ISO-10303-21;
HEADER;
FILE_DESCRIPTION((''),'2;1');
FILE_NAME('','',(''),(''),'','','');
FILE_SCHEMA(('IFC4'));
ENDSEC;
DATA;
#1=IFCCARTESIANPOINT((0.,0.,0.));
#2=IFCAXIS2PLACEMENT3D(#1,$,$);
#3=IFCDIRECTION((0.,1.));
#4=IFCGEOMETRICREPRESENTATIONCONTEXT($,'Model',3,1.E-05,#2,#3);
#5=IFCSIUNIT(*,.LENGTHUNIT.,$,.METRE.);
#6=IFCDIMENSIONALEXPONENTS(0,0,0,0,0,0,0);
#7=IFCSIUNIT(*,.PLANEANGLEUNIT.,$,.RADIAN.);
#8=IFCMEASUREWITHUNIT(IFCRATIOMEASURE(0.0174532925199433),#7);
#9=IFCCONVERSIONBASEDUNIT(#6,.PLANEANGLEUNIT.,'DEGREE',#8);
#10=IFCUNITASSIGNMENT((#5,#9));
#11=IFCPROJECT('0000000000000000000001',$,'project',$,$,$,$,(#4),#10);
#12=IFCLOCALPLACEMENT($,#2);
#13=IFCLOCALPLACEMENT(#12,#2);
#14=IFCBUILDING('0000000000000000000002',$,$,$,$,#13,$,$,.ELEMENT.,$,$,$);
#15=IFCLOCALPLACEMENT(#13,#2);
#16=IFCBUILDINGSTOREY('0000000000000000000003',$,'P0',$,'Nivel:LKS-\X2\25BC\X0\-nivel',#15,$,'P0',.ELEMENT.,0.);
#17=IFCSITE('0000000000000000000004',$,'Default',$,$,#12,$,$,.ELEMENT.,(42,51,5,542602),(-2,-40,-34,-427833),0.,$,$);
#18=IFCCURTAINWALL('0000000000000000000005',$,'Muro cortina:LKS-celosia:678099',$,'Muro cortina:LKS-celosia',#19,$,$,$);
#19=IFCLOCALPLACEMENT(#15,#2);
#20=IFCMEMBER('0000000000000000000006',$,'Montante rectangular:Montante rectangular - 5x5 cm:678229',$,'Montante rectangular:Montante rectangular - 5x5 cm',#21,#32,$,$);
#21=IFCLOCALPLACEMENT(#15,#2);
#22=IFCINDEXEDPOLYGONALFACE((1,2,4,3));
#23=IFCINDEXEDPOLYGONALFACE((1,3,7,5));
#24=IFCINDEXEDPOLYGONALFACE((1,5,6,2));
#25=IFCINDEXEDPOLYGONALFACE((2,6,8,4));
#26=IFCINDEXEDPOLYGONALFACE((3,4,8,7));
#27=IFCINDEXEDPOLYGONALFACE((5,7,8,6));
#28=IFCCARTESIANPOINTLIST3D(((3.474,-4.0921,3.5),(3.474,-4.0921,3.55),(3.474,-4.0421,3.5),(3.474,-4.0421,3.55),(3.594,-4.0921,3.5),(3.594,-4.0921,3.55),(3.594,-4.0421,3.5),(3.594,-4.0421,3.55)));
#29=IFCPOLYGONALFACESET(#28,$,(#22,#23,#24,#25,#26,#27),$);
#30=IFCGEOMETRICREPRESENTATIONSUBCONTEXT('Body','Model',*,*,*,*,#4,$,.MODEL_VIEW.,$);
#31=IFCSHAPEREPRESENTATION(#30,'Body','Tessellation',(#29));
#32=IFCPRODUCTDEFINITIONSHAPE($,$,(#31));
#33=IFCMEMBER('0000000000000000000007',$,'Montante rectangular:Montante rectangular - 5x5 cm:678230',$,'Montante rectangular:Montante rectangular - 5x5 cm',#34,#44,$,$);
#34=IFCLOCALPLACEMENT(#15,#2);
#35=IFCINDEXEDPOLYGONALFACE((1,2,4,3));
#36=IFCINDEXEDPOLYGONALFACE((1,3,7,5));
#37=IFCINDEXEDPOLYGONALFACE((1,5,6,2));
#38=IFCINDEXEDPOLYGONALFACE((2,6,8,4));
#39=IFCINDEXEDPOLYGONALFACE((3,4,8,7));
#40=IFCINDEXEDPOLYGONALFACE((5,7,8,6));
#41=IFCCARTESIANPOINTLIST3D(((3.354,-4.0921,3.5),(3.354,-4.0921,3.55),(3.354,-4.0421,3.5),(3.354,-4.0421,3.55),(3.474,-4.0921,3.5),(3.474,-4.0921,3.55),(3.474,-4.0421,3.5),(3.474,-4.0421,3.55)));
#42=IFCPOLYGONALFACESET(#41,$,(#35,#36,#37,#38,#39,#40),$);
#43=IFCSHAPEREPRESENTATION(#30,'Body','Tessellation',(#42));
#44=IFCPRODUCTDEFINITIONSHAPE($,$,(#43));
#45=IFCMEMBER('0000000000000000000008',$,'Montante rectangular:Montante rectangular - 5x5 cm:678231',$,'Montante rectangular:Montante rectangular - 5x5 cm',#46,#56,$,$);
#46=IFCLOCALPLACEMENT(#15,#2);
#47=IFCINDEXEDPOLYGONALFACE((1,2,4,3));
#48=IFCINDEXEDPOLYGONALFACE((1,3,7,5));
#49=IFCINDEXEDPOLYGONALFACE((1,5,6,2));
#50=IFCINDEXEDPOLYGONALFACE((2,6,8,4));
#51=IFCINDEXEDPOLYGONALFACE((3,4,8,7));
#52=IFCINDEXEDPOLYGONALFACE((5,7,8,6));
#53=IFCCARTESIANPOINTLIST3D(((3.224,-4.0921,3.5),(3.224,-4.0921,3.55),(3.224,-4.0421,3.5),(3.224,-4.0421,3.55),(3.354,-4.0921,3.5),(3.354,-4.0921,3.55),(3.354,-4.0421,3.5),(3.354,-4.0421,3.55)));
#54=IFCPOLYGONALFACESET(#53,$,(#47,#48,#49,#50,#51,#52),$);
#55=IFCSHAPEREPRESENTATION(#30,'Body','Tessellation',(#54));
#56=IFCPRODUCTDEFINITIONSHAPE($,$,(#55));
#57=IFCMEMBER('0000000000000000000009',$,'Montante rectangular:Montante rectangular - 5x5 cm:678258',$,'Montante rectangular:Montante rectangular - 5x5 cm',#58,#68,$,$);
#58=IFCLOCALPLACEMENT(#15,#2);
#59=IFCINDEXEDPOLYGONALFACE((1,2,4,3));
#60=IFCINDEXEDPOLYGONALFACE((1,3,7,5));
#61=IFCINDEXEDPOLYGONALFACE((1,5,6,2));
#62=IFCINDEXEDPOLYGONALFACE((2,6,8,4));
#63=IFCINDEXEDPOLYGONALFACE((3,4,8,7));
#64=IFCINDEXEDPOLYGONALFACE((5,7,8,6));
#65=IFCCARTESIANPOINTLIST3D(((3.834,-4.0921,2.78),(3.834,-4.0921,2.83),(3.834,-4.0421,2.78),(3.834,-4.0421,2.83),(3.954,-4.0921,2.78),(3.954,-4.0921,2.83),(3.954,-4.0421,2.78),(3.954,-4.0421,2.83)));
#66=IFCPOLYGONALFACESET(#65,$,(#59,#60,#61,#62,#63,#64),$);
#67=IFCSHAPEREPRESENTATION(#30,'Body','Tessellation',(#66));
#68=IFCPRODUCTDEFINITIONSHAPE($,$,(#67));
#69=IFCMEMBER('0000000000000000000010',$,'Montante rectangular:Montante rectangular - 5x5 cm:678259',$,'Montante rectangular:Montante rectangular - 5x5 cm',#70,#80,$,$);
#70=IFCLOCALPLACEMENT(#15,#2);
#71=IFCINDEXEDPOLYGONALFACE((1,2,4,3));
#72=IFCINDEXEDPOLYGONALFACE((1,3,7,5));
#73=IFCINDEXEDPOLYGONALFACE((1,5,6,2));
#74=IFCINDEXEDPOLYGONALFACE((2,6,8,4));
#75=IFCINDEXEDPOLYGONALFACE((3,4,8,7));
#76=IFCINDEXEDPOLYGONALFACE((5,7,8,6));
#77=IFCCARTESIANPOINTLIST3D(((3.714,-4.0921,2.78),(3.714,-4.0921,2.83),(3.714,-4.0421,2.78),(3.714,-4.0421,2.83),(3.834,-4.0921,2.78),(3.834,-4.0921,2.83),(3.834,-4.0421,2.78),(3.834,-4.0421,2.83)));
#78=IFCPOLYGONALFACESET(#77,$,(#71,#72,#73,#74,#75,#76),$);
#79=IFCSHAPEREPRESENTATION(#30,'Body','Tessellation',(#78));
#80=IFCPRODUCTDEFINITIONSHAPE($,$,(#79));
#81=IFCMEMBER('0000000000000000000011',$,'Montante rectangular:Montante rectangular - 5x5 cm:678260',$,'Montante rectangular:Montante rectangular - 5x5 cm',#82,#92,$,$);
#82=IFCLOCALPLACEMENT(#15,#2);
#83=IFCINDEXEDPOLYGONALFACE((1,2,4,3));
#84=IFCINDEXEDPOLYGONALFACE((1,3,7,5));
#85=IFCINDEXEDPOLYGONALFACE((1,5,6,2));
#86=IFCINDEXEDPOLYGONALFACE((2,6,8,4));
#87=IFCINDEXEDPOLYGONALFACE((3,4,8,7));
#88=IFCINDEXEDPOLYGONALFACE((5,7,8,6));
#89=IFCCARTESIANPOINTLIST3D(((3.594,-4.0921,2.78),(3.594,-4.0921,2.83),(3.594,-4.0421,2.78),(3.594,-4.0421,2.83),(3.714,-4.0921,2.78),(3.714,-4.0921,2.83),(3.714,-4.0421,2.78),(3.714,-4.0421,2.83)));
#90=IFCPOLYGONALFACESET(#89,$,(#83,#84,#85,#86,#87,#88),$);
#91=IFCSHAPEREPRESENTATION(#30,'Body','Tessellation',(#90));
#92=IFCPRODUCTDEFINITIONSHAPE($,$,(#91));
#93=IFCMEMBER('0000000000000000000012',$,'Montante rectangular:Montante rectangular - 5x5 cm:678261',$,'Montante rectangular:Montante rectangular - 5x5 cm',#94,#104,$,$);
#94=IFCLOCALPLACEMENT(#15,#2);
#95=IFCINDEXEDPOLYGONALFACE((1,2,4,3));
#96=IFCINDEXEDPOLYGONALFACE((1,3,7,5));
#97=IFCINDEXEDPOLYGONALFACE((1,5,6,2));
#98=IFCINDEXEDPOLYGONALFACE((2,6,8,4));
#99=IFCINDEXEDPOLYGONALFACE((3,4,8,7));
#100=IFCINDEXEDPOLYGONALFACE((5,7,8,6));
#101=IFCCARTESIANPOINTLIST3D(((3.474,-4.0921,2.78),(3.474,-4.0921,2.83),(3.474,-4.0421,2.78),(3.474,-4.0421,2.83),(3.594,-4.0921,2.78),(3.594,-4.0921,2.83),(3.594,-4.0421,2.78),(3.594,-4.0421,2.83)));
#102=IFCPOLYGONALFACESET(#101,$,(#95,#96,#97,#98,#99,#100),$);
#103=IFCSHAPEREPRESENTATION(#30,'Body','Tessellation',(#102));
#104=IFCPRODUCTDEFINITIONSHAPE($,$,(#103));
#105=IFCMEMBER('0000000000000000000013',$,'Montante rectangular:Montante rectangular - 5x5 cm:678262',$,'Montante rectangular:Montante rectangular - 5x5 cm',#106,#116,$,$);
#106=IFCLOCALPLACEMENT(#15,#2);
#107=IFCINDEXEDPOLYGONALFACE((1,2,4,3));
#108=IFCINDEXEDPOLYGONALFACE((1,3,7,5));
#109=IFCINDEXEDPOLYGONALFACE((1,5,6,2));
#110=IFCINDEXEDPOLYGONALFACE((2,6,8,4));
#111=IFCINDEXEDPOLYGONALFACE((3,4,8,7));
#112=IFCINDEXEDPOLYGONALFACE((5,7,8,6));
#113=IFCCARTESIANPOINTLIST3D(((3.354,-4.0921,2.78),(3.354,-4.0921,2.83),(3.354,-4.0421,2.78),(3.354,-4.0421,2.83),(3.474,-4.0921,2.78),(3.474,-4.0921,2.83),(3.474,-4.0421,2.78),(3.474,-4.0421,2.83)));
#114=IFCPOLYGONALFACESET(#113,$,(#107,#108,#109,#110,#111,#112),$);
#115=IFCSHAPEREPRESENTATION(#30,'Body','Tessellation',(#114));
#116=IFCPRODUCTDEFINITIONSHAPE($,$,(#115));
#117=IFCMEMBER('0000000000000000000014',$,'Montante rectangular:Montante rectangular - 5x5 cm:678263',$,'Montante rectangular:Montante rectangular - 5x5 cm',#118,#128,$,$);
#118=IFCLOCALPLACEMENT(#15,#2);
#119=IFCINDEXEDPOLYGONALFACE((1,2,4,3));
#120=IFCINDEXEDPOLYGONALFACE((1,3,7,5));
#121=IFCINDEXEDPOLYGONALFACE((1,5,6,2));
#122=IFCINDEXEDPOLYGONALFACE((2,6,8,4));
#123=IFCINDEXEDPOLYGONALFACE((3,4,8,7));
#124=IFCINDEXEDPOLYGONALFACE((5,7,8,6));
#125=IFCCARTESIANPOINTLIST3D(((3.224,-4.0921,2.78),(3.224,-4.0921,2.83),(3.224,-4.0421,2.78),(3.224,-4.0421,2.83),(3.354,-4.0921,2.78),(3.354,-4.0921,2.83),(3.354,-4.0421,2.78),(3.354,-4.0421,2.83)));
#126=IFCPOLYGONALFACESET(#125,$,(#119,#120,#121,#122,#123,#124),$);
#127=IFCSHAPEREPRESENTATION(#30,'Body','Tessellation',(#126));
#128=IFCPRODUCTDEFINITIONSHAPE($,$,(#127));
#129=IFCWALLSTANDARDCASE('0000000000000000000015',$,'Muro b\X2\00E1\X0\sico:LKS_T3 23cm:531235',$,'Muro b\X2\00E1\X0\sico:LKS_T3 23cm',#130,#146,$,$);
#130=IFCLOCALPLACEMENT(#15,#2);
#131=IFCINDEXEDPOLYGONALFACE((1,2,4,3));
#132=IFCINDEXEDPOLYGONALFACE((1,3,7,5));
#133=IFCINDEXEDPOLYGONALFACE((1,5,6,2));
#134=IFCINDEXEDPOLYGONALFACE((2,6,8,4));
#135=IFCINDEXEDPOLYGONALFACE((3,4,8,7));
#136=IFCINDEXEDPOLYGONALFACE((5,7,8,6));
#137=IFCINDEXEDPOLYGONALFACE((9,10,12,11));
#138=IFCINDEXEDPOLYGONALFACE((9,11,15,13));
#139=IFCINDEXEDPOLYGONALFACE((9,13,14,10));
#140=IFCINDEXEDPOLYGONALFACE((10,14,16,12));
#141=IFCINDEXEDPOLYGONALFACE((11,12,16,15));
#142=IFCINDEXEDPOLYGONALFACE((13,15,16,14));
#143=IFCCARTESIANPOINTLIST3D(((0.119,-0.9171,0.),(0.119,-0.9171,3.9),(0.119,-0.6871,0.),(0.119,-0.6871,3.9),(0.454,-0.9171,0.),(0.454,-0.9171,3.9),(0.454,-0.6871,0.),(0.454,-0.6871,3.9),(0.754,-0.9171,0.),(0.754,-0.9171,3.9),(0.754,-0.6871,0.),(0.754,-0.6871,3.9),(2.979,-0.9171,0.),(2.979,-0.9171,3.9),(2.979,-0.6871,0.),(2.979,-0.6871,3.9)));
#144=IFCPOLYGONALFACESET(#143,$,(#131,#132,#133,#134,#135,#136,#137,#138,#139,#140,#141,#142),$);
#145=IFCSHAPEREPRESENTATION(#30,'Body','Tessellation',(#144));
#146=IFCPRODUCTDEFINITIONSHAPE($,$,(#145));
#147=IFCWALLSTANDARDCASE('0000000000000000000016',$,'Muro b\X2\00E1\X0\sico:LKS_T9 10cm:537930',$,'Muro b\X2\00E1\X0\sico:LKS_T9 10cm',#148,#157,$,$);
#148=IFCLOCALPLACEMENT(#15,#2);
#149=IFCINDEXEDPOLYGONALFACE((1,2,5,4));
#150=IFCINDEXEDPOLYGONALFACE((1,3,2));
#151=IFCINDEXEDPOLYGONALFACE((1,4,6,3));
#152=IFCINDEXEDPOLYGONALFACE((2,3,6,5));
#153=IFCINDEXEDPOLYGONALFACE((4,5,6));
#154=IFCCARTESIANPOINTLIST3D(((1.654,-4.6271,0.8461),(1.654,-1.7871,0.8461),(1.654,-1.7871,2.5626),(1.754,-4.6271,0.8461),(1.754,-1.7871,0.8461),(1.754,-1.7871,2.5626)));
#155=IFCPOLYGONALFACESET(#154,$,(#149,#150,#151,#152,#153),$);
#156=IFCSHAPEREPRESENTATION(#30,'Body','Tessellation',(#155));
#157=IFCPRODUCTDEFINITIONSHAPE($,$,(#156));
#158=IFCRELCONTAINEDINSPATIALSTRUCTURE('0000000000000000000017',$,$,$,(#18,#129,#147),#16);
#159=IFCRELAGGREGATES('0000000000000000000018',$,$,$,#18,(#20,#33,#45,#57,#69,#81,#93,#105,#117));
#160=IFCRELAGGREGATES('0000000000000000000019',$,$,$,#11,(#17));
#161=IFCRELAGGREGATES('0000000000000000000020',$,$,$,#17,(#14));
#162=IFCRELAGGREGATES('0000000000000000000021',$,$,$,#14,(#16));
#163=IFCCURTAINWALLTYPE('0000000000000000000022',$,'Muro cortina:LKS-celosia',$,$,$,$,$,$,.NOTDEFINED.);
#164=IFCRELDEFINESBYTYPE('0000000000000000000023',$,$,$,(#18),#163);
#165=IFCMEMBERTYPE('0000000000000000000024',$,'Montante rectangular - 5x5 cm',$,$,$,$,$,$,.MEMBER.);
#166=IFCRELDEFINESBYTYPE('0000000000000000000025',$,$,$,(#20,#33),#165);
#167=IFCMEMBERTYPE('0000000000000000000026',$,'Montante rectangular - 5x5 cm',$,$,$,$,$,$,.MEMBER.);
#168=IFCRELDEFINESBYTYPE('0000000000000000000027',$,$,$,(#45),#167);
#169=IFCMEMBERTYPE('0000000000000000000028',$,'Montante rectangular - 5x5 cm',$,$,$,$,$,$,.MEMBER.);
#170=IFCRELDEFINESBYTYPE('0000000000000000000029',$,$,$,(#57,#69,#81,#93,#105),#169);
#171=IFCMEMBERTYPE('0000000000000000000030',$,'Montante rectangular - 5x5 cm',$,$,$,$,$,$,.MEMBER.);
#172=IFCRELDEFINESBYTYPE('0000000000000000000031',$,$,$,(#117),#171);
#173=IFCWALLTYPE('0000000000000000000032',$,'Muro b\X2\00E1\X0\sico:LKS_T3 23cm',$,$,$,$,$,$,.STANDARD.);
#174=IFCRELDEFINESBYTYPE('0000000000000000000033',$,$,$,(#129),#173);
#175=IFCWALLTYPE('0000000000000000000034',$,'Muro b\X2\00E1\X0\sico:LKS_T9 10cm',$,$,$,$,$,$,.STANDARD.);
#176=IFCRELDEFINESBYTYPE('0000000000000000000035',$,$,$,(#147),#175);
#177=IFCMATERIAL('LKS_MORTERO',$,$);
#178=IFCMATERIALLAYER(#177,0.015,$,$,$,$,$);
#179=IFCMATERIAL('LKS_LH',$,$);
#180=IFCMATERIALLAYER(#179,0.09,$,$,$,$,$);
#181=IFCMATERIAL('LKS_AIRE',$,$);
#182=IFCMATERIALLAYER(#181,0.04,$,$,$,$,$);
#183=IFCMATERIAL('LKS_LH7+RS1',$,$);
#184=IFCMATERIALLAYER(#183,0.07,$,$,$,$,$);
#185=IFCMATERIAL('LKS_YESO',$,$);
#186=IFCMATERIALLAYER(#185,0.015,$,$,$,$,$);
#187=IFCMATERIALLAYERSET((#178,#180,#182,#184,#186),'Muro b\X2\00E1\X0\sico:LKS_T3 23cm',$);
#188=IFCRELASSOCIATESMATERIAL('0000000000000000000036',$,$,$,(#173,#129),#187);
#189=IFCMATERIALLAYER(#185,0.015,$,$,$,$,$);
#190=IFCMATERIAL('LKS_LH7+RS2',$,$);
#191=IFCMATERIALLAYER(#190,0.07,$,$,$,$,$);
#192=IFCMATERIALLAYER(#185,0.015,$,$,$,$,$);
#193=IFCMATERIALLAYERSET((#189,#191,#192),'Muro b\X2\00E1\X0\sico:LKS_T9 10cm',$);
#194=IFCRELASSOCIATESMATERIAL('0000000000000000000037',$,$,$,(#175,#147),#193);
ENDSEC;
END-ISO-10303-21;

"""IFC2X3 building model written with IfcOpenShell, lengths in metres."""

from ifc_helpers import new_model, entity, si_unit, converted_unit, direction, frame, frame_2d, origin, origin_2d_with_axis, place, context, subcontext, project, spatial, rectangle, extrude, clip, halfspace, source, transform, mapped, material, layer, layer_set, layer_usage, type_object, type_shapes, element, aggregate, save


model = new_model("IFC2X3")

# Units and contexts
model_context = context("Model", 3, precision=1e-05, world=origin(), true_north=direction((0.0, 1.0)))
body_context = subcontext(model_context, "Body", "Model", "MODEL_VIEW")
ifc_project = project(units=[si_unit("LENGTHUNIT", "METRE"), converted_unit("PLANEANGLEUNIT", "DEGREE", entity("IfcRatioMeasure", 0.0174532925199433), si_unit("PLANEANGLEUNIT", "RADIAN"), dimensions=[0, 0, 0, 0, 0, 0, 0])], contexts=[model_context])

# Site, building, storey
site_placement = place(None, origin())
site = spatial("IfcSite", under=ifc_project, at=site_placement, Name="Default", CompositionType="ELEMENT", RefLatitude=(42, 51, 5, 542602), RefLongitude=(-2, -40, -34, -427833), RefElevation=0.0)
building_placement = place(site_placement, origin())
building = spatial("IfcBuilding", under=site, at=building_placement, CompositionType="ELEMENT")
storey_placement = place(building_placement, origin())
storey = spatial("IfcBuildingStorey", under=building, at=storey_placement, Name="P0", ObjectType="Nivel:LKS-▼-nivel", LongName="P0", CompositionType="ELEMENT", Elevation=0.0)

# Curtain wall, members
curtain_wall_type = type_object("IfcCurtainWallType", Name="Muro cortina:LKS-celosia", PredefinedType="NOTDEFINED")
curtain_wall_placement = place(storey_placement, origin())
curtain_wall = element("IfcCurtainWall", 1, at=curtain_wall_placement, inside=storey, type_object=curtain_wall_type, Name="Muro cortina:LKS-celosia:678099", ObjectType="Muro cortina:LKS-celosia")
member_type_1 = type_object("IfcMemberType", Name="Montante rectangular - 5x5 cm", PredefinedType="MEMBER")
shared_shape_1 = source(origin(), body_context, "Body", "SweptSolid", [
    extrude(rectangle(XDim=0.05, YDim=0.05, at=origin_2d_with_axis()), frame((-0.025, -0.1, -0.12), z_axis=(0.0, 0.0, 1.0), x_axis=(0.0, -1.0, 0.0)), (0.0, 0.0, 1.0), 0.12),
])
type_shapes(member_type_1, [shared_shape_1])
member_1_placement = place(storey_placement, frame((3.594, -4.1671, 3.55), z_axis=(1.0, 0.0, 0.0), x_axis=(0.0, 0.0, 1.0)))
member_1 = element("IfcMember", 2, at=member_1_placement, type_object=member_type_1, Name="Montante rectangular:Montante rectangular - 5x5 cm:678229", ObjectType="Montante rectangular:Montante rectangular - 5x5 cm", context=body_context, shape_type="MappedRepresentation", body=[
    mapped(shared_shape_1, transform((0.0, 0.0, 0.0), scale=1.0)),
])
member_2_placement = place(storey_placement, frame((3.474, -4.1671, 3.55), z_axis=(1.0, 0.0, 0.0), x_axis=(0.0, 0.0, 1.0)))
member_2 = element("IfcMember", 3, at=member_2_placement, type_object=member_type_1, Name="Montante rectangular:Montante rectangular - 5x5 cm:678230", ObjectType="Montante rectangular:Montante rectangular - 5x5 cm", context=body_context, shape_type="MappedRepresentation", body=[
    mapped(shared_shape_1, transform((0.0, 0.0, 0.0), scale=1.0)),
])
member_type_2 = type_object("IfcMemberType", Name="Montante rectangular - 5x5 cm", PredefinedType="MEMBER")
shared_shape_2 = source(origin(), body_context, "Body", "SweptSolid", [
    extrude(rectangle(XDim=0.05, YDim=0.05, at=origin_2d_with_axis()), frame((-0.025, -0.1, -0.13), z_axis=(0.0, 0.0, 1.0), x_axis=(0.0, -1.0, 0.0)), (0.0, 0.0, 1.0), 0.13),
])
type_shapes(member_type_2, [shared_shape_2])
member_3_placement = place(storey_placement, frame((3.354, -4.1671, 3.55), z_axis=(1.0, 0.0, 0.0), x_axis=(0.0, 0.0, 1.0)))
member_3 = element("IfcMember", 4, at=member_3_placement, type_object=member_type_2, Name="Montante rectangular:Montante rectangular - 5x5 cm:678231", ObjectType="Montante rectangular:Montante rectangular - 5x5 cm", context=body_context, shape_type="MappedRepresentation", body=[
    mapped(shared_shape_2, transform((0.0, 0.0, 0.0), scale=1.0)),
])
member_type_3 = type_object("IfcMemberType", Name="Montante rectangular - 5x5 cm", PredefinedType="MEMBER")
shared_shape_3 = source(origin(), body_context, "Body", "SweptSolid", [
    extrude(rectangle(XDim=0.05, YDim=0.05, at=origin_2d_with_axis()), frame((-0.025, -0.1, -0.12), z_axis=(0.0, 0.0, 1.0), x_axis=(0.0, -1.0, 0.0)), (0.0, 0.0, 1.0), 0.12),
])
type_shapes(member_type_3, [shared_shape_3])
member_4_placement = place(storey_placement, frame((3.834, -4.1671, 2.78), z_axis=(-1.0, 0.0, 0.0), x_axis=(0.0, 0.0, -1.0)))
member_4 = element("IfcMember", 5, at=member_4_placement, type_object=member_type_3, Name="Montante rectangular:Montante rectangular - 5x5 cm:678258", ObjectType="Montante rectangular:Montante rectangular - 5x5 cm", context=body_context, shape_type="MappedRepresentation", body=[
    mapped(shared_shape_3, transform((0.0, 0.0, 0.0), scale=1.0)),
])
member_5_placement = place(storey_placement, frame((3.714, -4.1671, 2.78), z_axis=(-1.0, 0.0, 0.0), x_axis=(0.0, 0.0, -1.0)))
member_5 = element("IfcMember", 6, at=member_5_placement, type_object=member_type_3, Name="Montante rectangular:Montante rectangular - 5x5 cm:678259", ObjectType="Montante rectangular:Montante rectangular - 5x5 cm", context=body_context, shape_type="MappedRepresentation", body=[
    mapped(shared_shape_3, transform((0.0, 0.0, 0.0), scale=1.0)),
])
member_6_placement = place(storey_placement, frame((3.594, -4.1671, 2.78), z_axis=(-1.0, 0.0, 0.0), x_axis=(0.0, 0.0, -1.0)))
member_6 = element("IfcMember", 7, at=member_6_placement, type_object=member_type_3, Name="Montante rectangular:Montante rectangular - 5x5 cm:678260", ObjectType="Montante rectangular:Montante rectangular - 5x5 cm", context=body_context, shape_type="MappedRepresentation", body=[
    mapped(shared_shape_3, transform((0.0, 0.0, 0.0), scale=1.0)),
])
member_7_placement = place(storey_placement, frame((3.474, -4.1671, 2.78), z_axis=(-1.0, 0.0, 0.0), x_axis=(0.0, 0.0, -1.0)))
member_7 = element("IfcMember", 8, at=member_7_placement, type_object=member_type_3, Name="Montante rectangular:Montante rectangular - 5x5 cm:678261", ObjectType="Montante rectangular:Montante rectangular - 5x5 cm", context=body_context, shape_type="MappedRepresentation", body=[
    mapped(shared_shape_3, transform((0.0, 0.0, 0.0), scale=1.0)),
])
member_8_placement = place(storey_placement, frame((3.354, -4.1671, 2.78), z_axis=(-1.0, 0.0, 0.0), x_axis=(0.0, 0.0, -1.0)))
member_8 = element("IfcMember", 9, at=member_8_placement, type_object=member_type_3, Name="Montante rectangular:Montante rectangular - 5x5 cm:678262", ObjectType="Montante rectangular:Montante rectangular - 5x5 cm", context=body_context, shape_type="MappedRepresentation", body=[
    mapped(shared_shape_3, transform((0.0, 0.0, 0.0), scale=1.0)),
])
member_type_4 = type_object("IfcMemberType", Name="Montante rectangular - 5x5 cm", PredefinedType="MEMBER")
shared_shape_4 = source(origin(), body_context, "Body", "SweptSolid", [
    extrude(rectangle(XDim=0.05, YDim=0.05, at=origin_2d_with_axis()), frame((-0.025, -0.1, -0.13), z_axis=(0.0, 0.0, 1.0), x_axis=(0.0, -1.0, 0.0)), (0.0, 0.0, 1.0), 0.13),
])
type_shapes(member_type_4, [shared_shape_4])
member_9_placement = place(storey_placement, frame((3.224, -4.1671, 2.78), z_axis=(-1.0, 0.0, 0.0), x_axis=(0.0, 0.0, -1.0)))
member_9 = element("IfcMember", 10, at=member_9_placement, type_object=member_type_4, Name="Montante rectangular:Montante rectangular - 5x5 cm:678263", ObjectType="Montante rectangular:Montante rectangular - 5x5 cm", context=body_context, shape_type="MappedRepresentation", body=[
    mapped(shared_shape_4, transform((0.0, 0.0, 0.0), scale=1.0)),
])
aggregate(curtain_wall, [member_1, member_2, member_3, member_4, member_5, member_6, member_7, member_8, member_9])

# Wall, opening
ifc_material_1 = material(Name="LKS_MORTERO")
ifc_layer_1 = layer(ifc_material_1, 0.015)
ifc_material_2 = material(Name="LKS_LH")
ifc_layer_2 = layer(ifc_material_2, 0.09)
ifc_material_3 = material(Name="LKS_AIRE")
ifc_layer_3 = layer(ifc_material_3, 0.04)
ifc_material_4 = material(Name="LKS_LH7+RS1")
ifc_layer_4 = layer(ifc_material_4, 0.07)
ifc_material_5 = material(Name="LKS_YESO")
ifc_layer_5 = layer(ifc_material_5, 0.015)
ifc_layer_set_1 = layer_set([ifc_layer_1, ifc_layer_2, ifc_layer_3, ifc_layer_4, ifc_layer_5], Name="Muro básico:LKS_T3 23cm")
ifc_layer_usage_1 = layer_usage(ifc_layer_set_1, "AXIS2", "NEGATIVE", 0.115)
wall_type_1 = type_object("IfcWallType", Name="Muro básico:LKS_T3 23cm", PredefinedType="STANDARD", material=ifc_layer_set_1)
wall_1_placement = place(storey_placement, frame((2.979, -0.8021, 0.0), z_axis=(0.0, 0.0, 1.0), x_axis=(-1.0, 0.0, 0.0)))
wall_1 = element("IfcWallStandardCase", 11, at=wall_1_placement, inside=storey, type_object=wall_type_1, material=ifc_layer_usage_1, Name="Muro básico:LKS_T3 23cm:531235", ObjectType="Muro básico:LKS_T3 23cm", context=body_context, shape_type="SweptSolid", body=[
    extrude(rectangle(XDim=2.86, YDim=0.23, at=frame_2d((1.43, 0.0), x_axis=(-1.0, 0.0))), origin(), (0.0, 0.0, 1.0), 3.9),
])
opening_1_placement = place(storey_placement, frame((2.979, -0.8021, 0.0), z_axis=(0.0, 0.0, 1.0), x_axis=(-1.0, 0.0, 0.0)))
element("IfcOpeningElement", 12, at=opening_1_placement, cuts=wall_1, ObjectType="Opening", context=body_context, shape_type="SweptSolid", body=[
    extrude(rectangle(XDim=3.9, YDim=0.23, at=frame_2d((0.0, 0.0), x_axis=(1.0, 0.0))), frame((2.525, 0.0, 1.95), z_axis=(-1.0, 0.0, 0.0), x_axis=(0.0, 0.0, 1.0)), (0.0, 0.0, 1.0), 0.3),
])

# Wall
ifc_layer_6 = layer(ifc_material_5, 0.015)
ifc_material_6 = material(Name="LKS_LH7+RS2")
ifc_layer_7 = layer(ifc_material_6, 0.07)
ifc_layer_8 = layer(ifc_material_5, 0.015)
ifc_layer_set_2 = layer_set([ifc_layer_6, ifc_layer_7, ifc_layer_8], Name="Muro básico:LKS_T9 10cm")
ifc_layer_usage_2 = layer_usage(ifc_layer_set_2, "AXIS2", "NEGATIVE", 0.05)
wall_type_2 = type_object("IfcWallType", Name="Muro básico:LKS_T9 10cm", PredefinedType="STANDARD", material=ifc_layer_set_2)
wall_2_placement = place(storey_placement, frame((1.704, -1.7871, 0.8461), z_axis=(0.0, 0.0, 1.0), x_axis=(0.0, -1.0, 0.0)))
element("IfcWallStandardCase", 13, at=wall_2_placement, inside=storey, type_object=wall_type_2, material=ifc_layer_usage_2, Name="Muro básico:LKS_T9 10cm:537930", ObjectType="Muro básico:LKS_T9 10cm", context=body_context, shape_type="Clipping", body=[
    clip(extrude(rectangle(XDim=2.84, YDim=0.1, at=frame_2d((1.42, 0.0), x_axis=(-1.0, 0.0))), origin(), (0.0, 0.0, 1.0), 1.7165), halfspace(frame((0.0, -0.05, 1.7165), z_axis=(0.517259, 0.0, 0.855829), x_axis=(0.0, 1.0, 0.0)), False)),
])

save(model, "model.ifc")
